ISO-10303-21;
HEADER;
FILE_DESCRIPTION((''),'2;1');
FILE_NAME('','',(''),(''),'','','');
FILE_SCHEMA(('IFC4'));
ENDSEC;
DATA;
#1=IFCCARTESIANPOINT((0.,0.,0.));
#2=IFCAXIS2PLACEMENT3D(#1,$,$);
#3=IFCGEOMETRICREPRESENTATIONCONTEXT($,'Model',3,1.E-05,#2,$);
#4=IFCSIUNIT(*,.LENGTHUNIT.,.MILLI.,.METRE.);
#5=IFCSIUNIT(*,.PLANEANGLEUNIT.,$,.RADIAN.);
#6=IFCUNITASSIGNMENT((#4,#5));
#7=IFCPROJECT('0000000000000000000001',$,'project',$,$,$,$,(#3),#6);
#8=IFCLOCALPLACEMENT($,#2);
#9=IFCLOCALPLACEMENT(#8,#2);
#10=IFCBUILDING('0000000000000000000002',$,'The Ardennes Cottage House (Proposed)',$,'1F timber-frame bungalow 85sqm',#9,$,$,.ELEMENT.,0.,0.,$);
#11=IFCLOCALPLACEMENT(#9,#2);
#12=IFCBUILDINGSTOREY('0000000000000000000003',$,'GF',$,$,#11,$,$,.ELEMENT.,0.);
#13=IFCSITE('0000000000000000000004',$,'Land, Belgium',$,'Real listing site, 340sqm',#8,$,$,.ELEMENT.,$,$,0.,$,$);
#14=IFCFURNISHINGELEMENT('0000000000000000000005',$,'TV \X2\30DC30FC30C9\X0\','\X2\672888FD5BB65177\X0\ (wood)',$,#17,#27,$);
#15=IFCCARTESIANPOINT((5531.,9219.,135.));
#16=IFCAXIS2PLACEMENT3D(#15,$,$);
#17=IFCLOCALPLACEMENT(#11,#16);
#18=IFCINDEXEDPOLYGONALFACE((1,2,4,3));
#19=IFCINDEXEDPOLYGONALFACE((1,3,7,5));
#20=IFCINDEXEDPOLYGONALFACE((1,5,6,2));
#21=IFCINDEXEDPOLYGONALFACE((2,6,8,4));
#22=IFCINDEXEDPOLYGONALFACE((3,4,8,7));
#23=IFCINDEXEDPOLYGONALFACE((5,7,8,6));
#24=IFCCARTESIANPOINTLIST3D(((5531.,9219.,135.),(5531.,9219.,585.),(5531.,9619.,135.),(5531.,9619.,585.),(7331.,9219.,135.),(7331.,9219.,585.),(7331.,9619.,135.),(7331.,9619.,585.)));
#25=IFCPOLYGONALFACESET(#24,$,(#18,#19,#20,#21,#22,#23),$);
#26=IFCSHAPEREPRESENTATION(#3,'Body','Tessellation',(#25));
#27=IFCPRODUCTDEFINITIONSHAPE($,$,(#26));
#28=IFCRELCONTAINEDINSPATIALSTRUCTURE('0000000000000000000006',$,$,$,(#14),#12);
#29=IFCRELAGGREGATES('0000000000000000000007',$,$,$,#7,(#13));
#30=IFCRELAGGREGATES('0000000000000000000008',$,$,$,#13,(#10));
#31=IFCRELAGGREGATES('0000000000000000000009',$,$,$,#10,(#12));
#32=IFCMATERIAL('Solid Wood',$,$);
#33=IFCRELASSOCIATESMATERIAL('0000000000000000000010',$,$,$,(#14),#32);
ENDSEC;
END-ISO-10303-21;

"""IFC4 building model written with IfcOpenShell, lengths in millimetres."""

from ifc_helpers import new_model, si_unit, frame, frame_2d, origin, place, context, project, spatial, rectangle, extrude, material, element, save


model = new_model("IFC4")

# Units and contexts
model_context = context("Model", 3, precision=1e-05, world=origin())
ifc_project = project(units=[si_unit("LENGTHUNIT", "METRE", prefix="MILLI"), si_unit("PLANEANGLEUNIT", "RADIAN")], contexts=[model_context])

# Site, building, storey
site_placement = place(None, origin())
site = spatial("IfcSite", under=ifc_project, at=site_placement, Name="Land, Belgium", ObjectType="Real listing site, 340sqm", CompositionType="ELEMENT", RefElevation=0.0)
building_placement = place(site_placement, origin())
building = spatial("IfcBuilding", under=site, at=building_placement, Name="The Ardennes Cottage House (Proposed)", ObjectType="1F timber-frame bungalow 85sqm", CompositionType="ELEMENT", ElevationOfRefHeight=0.0, ElevationOfTerrain=0.0)
storey_placement = place(building_placement, origin())
storey = spatial("IfcBuildingStorey", under=building, at=storey_placement, Name="GF", CompositionType="ELEMENT", Elevation=0.0)

# Shared definitions
ifc_material_1 = material(Name="Solid Wood")

# Furnishing element
furnishing_1_placement = place(storey_placement, frame((5531.0, 9219.0, 135.0)))
element("IfcFurnishingElement", 1, at=furnishing_1_placement, inside=storey, material=ifc_material_1, Name="TV ボード", Description="木製家具 (wood)", context=model_context, shape_type="SweptSolid", body=[
    extrude(rectangle(XDim=1800.0, YDim=400.0, at=frame_2d((900.0, 200.0))), frame((5531.0, 9219.0, 135.0)), (0.0, 0.0, 1.0), 450.0),
])

save(model, "model.ifc")
